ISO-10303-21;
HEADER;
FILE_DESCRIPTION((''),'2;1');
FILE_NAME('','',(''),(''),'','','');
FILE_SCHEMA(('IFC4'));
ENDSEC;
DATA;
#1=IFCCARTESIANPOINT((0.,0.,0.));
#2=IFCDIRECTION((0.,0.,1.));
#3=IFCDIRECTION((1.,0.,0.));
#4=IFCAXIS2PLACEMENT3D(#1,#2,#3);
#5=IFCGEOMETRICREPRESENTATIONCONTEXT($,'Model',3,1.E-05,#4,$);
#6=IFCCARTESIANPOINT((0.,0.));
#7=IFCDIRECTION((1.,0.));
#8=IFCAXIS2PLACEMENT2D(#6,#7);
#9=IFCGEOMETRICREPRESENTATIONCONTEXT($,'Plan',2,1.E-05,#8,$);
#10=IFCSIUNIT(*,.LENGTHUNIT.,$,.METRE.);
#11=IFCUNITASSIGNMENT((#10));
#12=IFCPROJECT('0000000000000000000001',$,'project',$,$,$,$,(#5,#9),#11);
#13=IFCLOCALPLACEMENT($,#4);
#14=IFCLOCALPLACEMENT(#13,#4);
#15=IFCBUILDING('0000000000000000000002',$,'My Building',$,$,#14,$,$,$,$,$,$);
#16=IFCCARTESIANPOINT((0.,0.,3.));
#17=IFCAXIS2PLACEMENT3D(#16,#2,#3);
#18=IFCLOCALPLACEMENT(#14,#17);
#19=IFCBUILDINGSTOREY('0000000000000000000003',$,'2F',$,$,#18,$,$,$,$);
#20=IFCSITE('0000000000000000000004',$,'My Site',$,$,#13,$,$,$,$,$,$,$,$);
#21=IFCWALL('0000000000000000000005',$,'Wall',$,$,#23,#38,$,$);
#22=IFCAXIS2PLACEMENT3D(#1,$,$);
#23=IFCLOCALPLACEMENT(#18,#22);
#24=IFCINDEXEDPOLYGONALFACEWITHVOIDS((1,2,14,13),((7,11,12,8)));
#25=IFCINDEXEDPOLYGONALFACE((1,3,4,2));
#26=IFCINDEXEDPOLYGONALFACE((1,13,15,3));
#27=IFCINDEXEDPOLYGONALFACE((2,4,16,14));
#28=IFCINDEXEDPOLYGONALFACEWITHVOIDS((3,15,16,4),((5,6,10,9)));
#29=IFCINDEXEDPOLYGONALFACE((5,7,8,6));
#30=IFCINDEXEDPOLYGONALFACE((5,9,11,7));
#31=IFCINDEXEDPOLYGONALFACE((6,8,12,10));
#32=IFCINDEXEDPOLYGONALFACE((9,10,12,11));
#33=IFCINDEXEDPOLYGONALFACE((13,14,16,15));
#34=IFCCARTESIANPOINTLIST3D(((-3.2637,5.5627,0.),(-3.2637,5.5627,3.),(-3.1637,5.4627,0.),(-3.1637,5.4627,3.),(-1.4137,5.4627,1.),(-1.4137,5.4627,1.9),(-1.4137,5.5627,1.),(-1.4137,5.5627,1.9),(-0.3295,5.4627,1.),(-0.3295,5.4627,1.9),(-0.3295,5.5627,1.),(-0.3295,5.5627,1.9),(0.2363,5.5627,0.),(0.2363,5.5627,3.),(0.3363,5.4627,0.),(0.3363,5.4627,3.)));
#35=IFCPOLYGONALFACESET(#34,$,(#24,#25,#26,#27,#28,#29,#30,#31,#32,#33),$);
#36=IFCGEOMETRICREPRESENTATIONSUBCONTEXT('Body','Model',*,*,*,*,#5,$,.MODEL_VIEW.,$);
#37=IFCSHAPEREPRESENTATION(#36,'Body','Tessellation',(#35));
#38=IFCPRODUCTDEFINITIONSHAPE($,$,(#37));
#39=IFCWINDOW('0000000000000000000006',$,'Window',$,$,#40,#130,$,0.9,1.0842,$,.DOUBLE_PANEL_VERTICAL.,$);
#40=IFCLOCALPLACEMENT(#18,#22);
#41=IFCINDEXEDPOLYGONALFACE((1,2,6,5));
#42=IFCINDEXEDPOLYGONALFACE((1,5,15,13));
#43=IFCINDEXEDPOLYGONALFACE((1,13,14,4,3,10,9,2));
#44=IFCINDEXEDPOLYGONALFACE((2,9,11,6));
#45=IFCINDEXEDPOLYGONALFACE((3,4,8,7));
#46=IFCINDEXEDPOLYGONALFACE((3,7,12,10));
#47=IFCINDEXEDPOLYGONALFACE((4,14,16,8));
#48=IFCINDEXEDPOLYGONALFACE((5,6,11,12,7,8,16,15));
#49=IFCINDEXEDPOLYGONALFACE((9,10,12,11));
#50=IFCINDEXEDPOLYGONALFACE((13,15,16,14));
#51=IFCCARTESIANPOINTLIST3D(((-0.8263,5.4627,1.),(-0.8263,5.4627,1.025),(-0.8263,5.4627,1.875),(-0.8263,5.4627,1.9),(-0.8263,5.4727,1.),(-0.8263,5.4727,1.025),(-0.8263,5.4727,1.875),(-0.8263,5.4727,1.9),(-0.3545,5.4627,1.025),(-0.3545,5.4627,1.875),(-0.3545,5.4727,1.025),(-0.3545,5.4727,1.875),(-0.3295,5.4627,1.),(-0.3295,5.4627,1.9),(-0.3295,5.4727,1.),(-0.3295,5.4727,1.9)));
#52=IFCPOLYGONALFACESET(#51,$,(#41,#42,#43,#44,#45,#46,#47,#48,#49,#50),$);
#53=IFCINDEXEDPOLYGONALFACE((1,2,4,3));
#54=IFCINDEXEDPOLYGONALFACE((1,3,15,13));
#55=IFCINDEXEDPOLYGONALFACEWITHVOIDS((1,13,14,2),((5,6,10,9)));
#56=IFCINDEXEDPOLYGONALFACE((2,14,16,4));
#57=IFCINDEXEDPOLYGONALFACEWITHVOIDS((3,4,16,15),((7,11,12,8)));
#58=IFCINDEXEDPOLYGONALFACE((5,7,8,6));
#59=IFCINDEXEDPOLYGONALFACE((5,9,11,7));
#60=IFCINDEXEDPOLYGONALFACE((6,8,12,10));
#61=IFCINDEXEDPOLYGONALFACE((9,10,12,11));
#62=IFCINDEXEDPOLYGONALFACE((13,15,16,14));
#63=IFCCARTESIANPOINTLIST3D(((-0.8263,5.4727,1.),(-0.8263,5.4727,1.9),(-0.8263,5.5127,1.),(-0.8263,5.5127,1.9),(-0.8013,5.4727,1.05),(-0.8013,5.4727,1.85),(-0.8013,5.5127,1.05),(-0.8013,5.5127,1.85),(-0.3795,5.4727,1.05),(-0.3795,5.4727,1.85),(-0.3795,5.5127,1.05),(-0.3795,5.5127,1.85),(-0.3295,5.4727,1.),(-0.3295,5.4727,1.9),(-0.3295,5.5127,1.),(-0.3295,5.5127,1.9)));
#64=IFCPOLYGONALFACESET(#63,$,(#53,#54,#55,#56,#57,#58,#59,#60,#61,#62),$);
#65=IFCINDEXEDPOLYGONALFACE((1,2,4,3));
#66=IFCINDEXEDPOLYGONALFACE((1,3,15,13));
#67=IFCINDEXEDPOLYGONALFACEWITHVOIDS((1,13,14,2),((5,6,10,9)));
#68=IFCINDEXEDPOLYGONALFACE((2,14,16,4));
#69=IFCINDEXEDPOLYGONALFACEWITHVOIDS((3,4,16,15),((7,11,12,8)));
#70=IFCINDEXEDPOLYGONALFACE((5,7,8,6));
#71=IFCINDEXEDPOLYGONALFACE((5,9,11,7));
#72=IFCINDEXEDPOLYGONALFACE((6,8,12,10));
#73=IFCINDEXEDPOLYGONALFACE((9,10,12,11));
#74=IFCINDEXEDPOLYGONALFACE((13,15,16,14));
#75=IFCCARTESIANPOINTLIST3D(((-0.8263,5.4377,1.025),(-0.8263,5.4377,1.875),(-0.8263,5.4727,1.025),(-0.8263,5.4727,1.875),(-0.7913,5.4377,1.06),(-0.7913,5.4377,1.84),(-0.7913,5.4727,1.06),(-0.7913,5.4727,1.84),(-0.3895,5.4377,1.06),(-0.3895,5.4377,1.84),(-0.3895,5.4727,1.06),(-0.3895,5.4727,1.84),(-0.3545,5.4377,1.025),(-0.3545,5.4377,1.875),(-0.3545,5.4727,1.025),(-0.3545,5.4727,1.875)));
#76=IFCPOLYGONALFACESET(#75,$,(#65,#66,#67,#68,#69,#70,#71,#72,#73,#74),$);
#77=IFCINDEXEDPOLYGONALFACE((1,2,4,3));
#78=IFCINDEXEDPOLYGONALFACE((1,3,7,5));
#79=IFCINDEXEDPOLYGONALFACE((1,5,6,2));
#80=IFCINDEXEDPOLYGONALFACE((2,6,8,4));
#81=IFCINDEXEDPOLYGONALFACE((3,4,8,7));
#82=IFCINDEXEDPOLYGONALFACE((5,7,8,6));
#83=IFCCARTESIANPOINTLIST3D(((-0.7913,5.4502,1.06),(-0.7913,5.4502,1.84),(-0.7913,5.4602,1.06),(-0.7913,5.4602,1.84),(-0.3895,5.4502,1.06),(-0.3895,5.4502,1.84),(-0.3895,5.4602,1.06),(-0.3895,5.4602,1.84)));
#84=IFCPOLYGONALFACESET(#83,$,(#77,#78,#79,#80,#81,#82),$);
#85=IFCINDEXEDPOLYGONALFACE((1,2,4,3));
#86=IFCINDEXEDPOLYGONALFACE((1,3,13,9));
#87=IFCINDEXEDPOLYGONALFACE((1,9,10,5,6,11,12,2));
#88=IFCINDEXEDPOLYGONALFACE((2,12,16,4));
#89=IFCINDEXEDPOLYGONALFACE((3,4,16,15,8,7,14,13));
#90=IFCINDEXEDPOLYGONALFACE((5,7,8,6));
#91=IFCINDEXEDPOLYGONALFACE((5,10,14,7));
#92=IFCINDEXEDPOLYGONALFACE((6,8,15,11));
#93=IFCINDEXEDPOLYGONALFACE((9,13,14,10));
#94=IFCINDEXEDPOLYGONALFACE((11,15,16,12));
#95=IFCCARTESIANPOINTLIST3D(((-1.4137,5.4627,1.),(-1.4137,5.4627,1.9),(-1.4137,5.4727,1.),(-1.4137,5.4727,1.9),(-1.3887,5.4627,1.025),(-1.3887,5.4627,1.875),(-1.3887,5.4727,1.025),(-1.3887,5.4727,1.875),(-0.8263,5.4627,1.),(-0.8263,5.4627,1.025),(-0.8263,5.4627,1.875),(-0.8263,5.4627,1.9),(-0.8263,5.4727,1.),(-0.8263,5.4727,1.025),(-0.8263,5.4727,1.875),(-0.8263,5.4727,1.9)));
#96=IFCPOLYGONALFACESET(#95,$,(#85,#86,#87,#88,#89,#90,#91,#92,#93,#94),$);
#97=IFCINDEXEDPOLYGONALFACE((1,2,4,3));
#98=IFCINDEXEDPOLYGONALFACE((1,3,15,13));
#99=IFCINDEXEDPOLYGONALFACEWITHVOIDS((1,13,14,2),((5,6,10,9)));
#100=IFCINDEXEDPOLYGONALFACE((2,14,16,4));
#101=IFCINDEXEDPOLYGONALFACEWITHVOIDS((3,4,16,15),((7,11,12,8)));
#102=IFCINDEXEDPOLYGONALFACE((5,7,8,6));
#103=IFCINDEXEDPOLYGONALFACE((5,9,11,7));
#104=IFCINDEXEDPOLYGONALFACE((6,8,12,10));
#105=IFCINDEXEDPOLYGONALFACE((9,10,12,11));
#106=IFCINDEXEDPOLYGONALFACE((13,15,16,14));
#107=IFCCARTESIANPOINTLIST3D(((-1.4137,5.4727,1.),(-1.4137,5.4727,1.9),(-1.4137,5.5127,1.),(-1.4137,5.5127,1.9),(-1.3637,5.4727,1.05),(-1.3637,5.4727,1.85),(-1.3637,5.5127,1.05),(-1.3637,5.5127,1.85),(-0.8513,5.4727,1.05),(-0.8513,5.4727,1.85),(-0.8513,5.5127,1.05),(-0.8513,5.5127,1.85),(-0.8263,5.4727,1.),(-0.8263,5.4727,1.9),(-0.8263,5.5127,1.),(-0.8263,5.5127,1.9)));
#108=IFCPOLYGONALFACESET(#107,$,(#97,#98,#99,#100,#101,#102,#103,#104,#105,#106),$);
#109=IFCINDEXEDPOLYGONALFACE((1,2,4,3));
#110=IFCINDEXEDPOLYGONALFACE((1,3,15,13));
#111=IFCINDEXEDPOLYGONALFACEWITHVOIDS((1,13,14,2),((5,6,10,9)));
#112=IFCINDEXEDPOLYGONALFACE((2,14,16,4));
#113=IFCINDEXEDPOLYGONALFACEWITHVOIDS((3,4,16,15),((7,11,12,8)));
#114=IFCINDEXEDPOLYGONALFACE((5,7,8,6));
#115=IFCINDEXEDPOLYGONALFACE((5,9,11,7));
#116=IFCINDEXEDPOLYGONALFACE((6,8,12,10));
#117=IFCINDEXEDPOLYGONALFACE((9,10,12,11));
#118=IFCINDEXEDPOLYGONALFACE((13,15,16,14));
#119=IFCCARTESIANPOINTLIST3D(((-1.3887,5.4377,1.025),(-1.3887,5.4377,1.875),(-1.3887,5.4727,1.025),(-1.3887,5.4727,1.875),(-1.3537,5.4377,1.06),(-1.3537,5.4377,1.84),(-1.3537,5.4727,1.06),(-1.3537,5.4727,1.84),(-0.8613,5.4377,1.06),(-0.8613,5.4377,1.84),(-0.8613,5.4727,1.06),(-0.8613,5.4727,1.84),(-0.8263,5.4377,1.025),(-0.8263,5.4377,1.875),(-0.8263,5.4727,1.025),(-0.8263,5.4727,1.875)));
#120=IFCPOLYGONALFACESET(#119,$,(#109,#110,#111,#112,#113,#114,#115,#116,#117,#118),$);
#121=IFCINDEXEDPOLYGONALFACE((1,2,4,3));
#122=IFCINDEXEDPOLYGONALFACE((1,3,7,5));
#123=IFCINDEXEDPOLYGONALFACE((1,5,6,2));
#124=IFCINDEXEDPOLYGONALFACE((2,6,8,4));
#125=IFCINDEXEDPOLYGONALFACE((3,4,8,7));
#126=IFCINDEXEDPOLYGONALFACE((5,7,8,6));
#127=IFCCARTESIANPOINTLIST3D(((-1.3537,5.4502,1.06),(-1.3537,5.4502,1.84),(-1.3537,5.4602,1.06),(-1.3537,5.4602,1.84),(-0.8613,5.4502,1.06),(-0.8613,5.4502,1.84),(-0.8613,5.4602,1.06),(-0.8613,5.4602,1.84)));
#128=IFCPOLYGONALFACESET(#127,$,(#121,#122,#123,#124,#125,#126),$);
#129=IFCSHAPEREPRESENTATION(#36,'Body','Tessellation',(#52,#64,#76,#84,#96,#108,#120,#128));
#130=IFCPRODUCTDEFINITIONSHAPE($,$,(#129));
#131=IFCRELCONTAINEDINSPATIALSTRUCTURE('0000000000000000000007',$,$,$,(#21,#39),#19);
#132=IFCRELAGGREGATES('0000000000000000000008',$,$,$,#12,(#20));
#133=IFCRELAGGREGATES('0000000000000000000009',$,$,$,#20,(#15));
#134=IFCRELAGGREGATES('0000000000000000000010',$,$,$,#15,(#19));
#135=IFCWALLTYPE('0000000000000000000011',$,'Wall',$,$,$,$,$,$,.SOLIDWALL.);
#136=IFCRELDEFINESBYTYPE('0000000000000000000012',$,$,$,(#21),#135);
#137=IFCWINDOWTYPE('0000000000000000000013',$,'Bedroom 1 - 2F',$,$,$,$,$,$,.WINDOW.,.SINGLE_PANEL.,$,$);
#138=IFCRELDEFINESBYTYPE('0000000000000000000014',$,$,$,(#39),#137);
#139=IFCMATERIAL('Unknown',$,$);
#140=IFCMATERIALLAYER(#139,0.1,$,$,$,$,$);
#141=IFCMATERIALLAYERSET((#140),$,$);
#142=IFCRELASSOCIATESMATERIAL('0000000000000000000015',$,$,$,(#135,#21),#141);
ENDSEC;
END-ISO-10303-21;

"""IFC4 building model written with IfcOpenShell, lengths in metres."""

from ifc_helpers import new_model, entity, si_unit, frame, origin_with_axes, origin_2d_with_axis, place, context, subcontext, project, spatial, line, indexed_curve, outline, extrude, shape, source, transform, mapped, material, layer, layer_set, layer_usage, type_object, type_shapes, element, fill, save


model = new_model("IFC4")

# Units and contexts
model_context = context("Model", 3, precision=1e-05, world=origin_with_axes())
plan_context = context("Plan", 2, precision=1e-05, world=origin_2d_with_axis())
body_context_1 = subcontext(model_context, "Body", "Model", "MODEL_VIEW")
body_context_2 = subcontext(plan_context, "Body", "Plan", "PLAN_VIEW")
ifc_project = project(units=[si_unit("LENGTHUNIT", "METRE")], contexts=[model_context, plan_context])

# Site, building, storey
site_placement = place(None, origin_with_axes())
site = spatial("IfcSite", under=ifc_project, at=site_placement, Name="My Site")
building_placement = place(site_placement, origin_with_axes())
building = spatial("IfcBuilding", under=site, at=building_placement, Name="My Building")
storey_placement = place(building_placement, frame((0.0, 0.0, 3.0), z_axis=(0.0, 0.0, 1.0), x_axis=(1.0, 0.0, 0.0)))
storey = spatial("IfcBuildingStorey", under=building, at=storey_placement, Name="2F")

# Shared definitions
ifc_material = material(Name="Unknown")

# Shared definitions
ifc_layer_1 = layer(ifc_material, 0.1)
ifc_layer_set_1 = layer_set([ifc_layer_1])
wall_type = type_object("IfcWallType", Name="Wall", PredefinedType="SOLIDWALL", material=ifc_layer_set_1)

# Wall, opening, window
ifc_layer_usage_1 = layer_usage(ifc_layer_set_1, "AXIS2", "POSITIVE", 0.0)
wall_1_placement = place(storey_placement, frame((0.2363, 5.5627, 0.0), z_axis=(0.0, 0.0, 1.0), x_axis=(-1.0, 0.0, 0.0)))
wall_1 = element("IfcWall", 1, at=wall_1_placement, inside=storey, type_object=wall_type, material=ifc_layer_usage_1, Name="Wall", context=body_context_1, shape_type="SweptSolid", body=[
    extrude(outline(indexed_curve([(0.0, 0.0), (-0.1, 0.1), (3.4, 0.1), (3.5, 0.0)], segments=[line(1, 2, 3, 4, 1)])), origin_with_axes(), (0.0, 0.0, 1.0), 3.0),
])
shared_shape_1 = source(origin_with_axes(), body_context_1, "Body", "SweptSolid", [
    extrude(outline(indexed_curve([(0.0, 0.0), (1.0842, 0.0), (1.0842, 0.9), (0.0, 0.9)], segments=[line(1, 2, 3, 4, 1)])), frame((0.0, -0.6, 0.0), z_axis=(0.0, -1.0, 0.0), x_axis=(1.0, 0.0, 0.0)), (0.0, 0.0, -1.0), 1.2),
])
opening_1_placement = place(wall_1_placement, frame((0.5658, 0.0, 1.0), z_axis=(0.0, 0.0, 1.0), x_axis=(1.0, 0.0, 0.0)))
opening_1 = element("IfcOpeningElement", 2, at=opening_1_placement, cuts=wall_1, PredefinedType="OPENING", context=body_context_1, shape_type="MappedRepresentation", body=[
    mapped(shared_shape_1, transform((0.0, 0.0, 0.0), x_axis=(1.0, 0.0, 0.0), y_axis=(0.0, 1.0, 0.0), z_axis=(0.0, 0.0, 1.0), scale=1.0)),
])
window_type_1 = type_object("IfcWindowType", Name="Bedroom 1 - 2F", PartitioningType="SINGLE_PANEL", PredefinedType="WINDOW")
shared_shape_2 = source(origin_with_axes(), body_context_1, "Body", "SweptSolid", [
    extrude(outline(indexed_curve([(0.4967, 0.0), (0.0, 0.0), (0.0, 0.9), (0.4967, 0.9), (0.4967, 0.875), (0.025, 0.875), (0.025, 0.025), (0.4967, 0.025)], segments=[line(1, 2, 3, 4, 5, 6, 7, 8, 1)])), frame((0.0, 0.09, 0.0), z_axis=(0.0, -1.0, 0.0), x_axis=(1.0, 0.0, 0.0)), (0.0, 0.0, -1.0), 0.01),
    extrude(outline(indexed_curve([(0.0, 0.0), (0.4967, 0.0), (0.4967, 0.9), (0.0, 0.9)], segments=[line(1, 2, 3, 4, 1)]), holes=[indexed_curve([(0.05, 0.05), (0.4717, 0.05), (0.4717, 0.85), (0.05, 0.85)], segments=[line(1, 2, 3, 4, 1)])]), frame((0.0, 0.05, 0.0), z_axis=(0.0, -1.0, 0.0), x_axis=(1.0, 0.0, 0.0)), (0.0, 0.0, -1.0), 0.04),
    extrude(outline(indexed_curve([(0.0, 0.0), (0.4717, 0.0), (0.4717, 0.85), (0.0, 0.85)], segments=[line(1, 2, 3, 4, 1)]), holes=[indexed_curve([(0.035, 0.035), (0.4367, 0.035), (0.4367, 0.815), (0.035, 0.815)], segments=[line(1, 2, 3, 4, 1)])]), frame((0.025, 0.09, 0.025), z_axis=(0.0, -1.0, 0.0), x_axis=(1.0, 0.0, 0.0)), (0.0, 0.0, -1.0), 0.035),
    extrude(outline(indexed_curve([(0.035, 0.035), (0.4367, 0.035), (0.4367, 0.815), (0.035, 0.815)], segments=[line(1, 2, 3, 4, 1)])), frame((0.025, 0.1025, 0.025), z_axis=(0.0, -1.0, 0.0), x_axis=(1.0, 0.0, 0.0)), (0.0, 0.0, -1.0), 0.01),
    extrude(outline(indexed_curve([(0.0, 0.9), (0.5874, 0.9), (0.5874, 0.0), (0.0, 0.0), (0.0, 0.025), (0.5624, 0.025), (0.5624, 0.875), (0.0, 0.875)], segments=[line(1, 2, 3, 4, 5, 6, 7, 8, 1)])), frame((0.4967, 0.09, 0.0), z_axis=(0.0, -1.0, 0.0), x_axis=(1.0, 0.0, 0.0)), (0.0, 0.0, -1.0), 0.01),
    extrude(outline(indexed_curve([(0.0, 0.0), (0.5874, 0.0), (0.5874, 0.9), (0.0, 0.9)], segments=[line(1, 2, 3, 4, 1)]), holes=[indexed_curve([(0.025, 0.05), (0.5374, 0.05), (0.5374, 0.85), (0.025, 0.85)], segments=[line(1, 2, 3, 4, 1)])]), frame((0.4967, 0.05, 0.0), z_axis=(0.0, -1.0, 0.0), x_axis=(1.0, 0.0, 0.0)), (0.0, 0.0, -1.0), 0.04),
    extrude(outline(indexed_curve([(0.0, 0.0), (0.5624, 0.0), (0.5624, 0.85), (0.0, 0.85)], segments=[line(1, 2, 3, 4, 1)]), holes=[indexed_curve([(0.035, 0.035), (0.5274, 0.035), (0.5274, 0.815), (0.035, 0.815)], segments=[line(1, 2, 3, 4, 1)])]), frame((0.4967, 0.09, 0.025), z_axis=(0.0, -1.0, 0.0), x_axis=(1.0, 0.0, 0.0)), (0.0, 0.0, -1.0), 0.035),
    extrude(outline(indexed_curve([(0.035, 0.035), (0.5274, 0.035), (0.5274, 0.815), (0.035, 0.815)], segments=[line(1, 2, 3, 4, 1)])), frame((0.4967, 0.1025, 0.025), z_axis=(0.0, -1.0, 0.0), x_axis=(1.0, 0.0, 0.0)), (0.0, 0.0, -1.0), 0.01),
])
shared_shape_3 = source(origin_with_axes(), body_context_2, "Body", "Curve2D", [
    entity("IfcIndexedPolyCurve", entity("IfcCartesianPointList2D", [[0.05, 0.05], [0.4717, 0.05]])),
    entity("IfcIndexedPolyCurve", entity("IfcCartesianPointList2D", [[0.0, 0.1], [0.025, 0.1], [0.025, 0.09], [0.05, 0.09], [0.05, 0.05], [0.0, 0.05]]), [entity("IfcLineIndex", [1, 2, 3, 4, 5, 6, 1])]),
    entity("IfcIndexedPolyCurve", entity("IfcCartesianPointList2D", [[0.4967, 0.1], [0.4967, 0.1], [0.4967, 0.09], [0.4717, 0.09], [0.4717, 0.05], [0.4967, 0.05]])),
    entity("IfcIndexedPolyCurve", entity("IfcCartesianPointList2D", [[0.025, 0.09], [0.06, 0.09], [0.06, 0.125], [0.025, 0.125]]), [entity("IfcLineIndex", [1, 2, 3, 4, 1])]),
    entity("IfcIndexedPolyCurve", entity("IfcCartesianPointList2D", [[0.4967, 0.09], [0.4617, 0.09], [0.4617, 0.125], [0.4967, 0.125]]), [entity("IfcLineIndex", [1, 2, 3, 4, 1])]),
    entity("IfcIndexedPolyCurve", entity("IfcCartesianPointList2D", [[0.06, 0.09], [0.4617, 0.09]])),
    entity("IfcIndexedPolyCurve", entity("IfcCartesianPointList2D", [[0.06, 0.125], [0.4617, 0.125]])),
    entity("IfcIndexedPolyCurve", entity("IfcCartesianPointList2D", [[0.06, 0.1075], [0.4617, 0.1075]])),
    entity("IfcIndexedPolyCurve", entity("IfcCartesianPointList2D", [[0.5217, 0.05], [1.0342, 0.05]])),
    entity("IfcIndexedPolyCurve", entity("IfcCartesianPointList2D", [[0.4967, 0.1], [0.4967, 0.1], [0.4967, 0.09], [0.5217, 0.09], [0.5217, 0.05], [0.4967, 0.05]])),
    entity("IfcIndexedPolyCurve", entity("IfcCartesianPointList2D", [[1.0842, 0.1], [1.0592, 0.1], [1.0592, 0.09], [1.0342, 0.09], [1.0342, 0.05], [1.0842, 0.05]]), [entity("IfcLineIndex", [1, 2, 3, 4, 5, 6, 1])]),
    entity("IfcIndexedPolyCurve", entity("IfcCartesianPointList2D", [[0.4967, 0.09], [0.5317, 0.09], [0.5317, 0.125], [0.4967, 0.125]]), [entity("IfcLineIndex", [1, 2, 3, 4, 1])]),
    entity("IfcIndexedPolyCurve", entity("IfcCartesianPointList2D", [[1.0592, 0.09], [1.0242, 0.09], [1.0242, 0.125], [1.0592, 0.125]]), [entity("IfcLineIndex", [1, 2, 3, 4, 1])]),
    entity("IfcIndexedPolyCurve", entity("IfcCartesianPointList2D", [[0.5317, 0.09], [1.0242, 0.09]])),
    entity("IfcIndexedPolyCurve", entity("IfcCartesianPointList2D", [[0.5317, 0.125], [1.0242, 0.125]])),
    entity("IfcIndexedPolyCurve", entity("IfcCartesianPointList2D", [[0.5317, 0.1075], [1.0242, 0.1075]])),
])
type_shapes(window_type_1, [shared_shape_2, shared_shape_3])
window_1_placement = place(opening_1_placement, origin_with_axes())
window_1 = element("IfcWindow", 3, at=window_1_placement, inside=storey, type_object=window_type_1, Name="Window", OverallHeight=0.9, OverallWidth=1.0842, PartitioningType="DOUBLE_PANEL_VERTICAL", shapes=[
    shape(body_context_1, "Body", "MappedRepresentation", [mapped(shared_shape_2, transform((0.0, 0.0, 0.0), x_axis=(1.0, 0.0, 0.0), y_axis=(0.0, 1.0, 0.0), z_axis=(0.0, 0.0, 1.0), scale=1.0))]),
    shape(body_context_2, "Body", "MappedRepresentation", [mapped(shared_shape_3, transform((0.0, 0.0, 0.0), x_axis=(1.0, 0.0, 0.0), y_axis=(0.0, 1.0, 0.0), z_axis=(0.0, 0.0, 1.0), scale=1.0))]),
])
fill(opening_1, window_1)

save(model, "model.ifc")
